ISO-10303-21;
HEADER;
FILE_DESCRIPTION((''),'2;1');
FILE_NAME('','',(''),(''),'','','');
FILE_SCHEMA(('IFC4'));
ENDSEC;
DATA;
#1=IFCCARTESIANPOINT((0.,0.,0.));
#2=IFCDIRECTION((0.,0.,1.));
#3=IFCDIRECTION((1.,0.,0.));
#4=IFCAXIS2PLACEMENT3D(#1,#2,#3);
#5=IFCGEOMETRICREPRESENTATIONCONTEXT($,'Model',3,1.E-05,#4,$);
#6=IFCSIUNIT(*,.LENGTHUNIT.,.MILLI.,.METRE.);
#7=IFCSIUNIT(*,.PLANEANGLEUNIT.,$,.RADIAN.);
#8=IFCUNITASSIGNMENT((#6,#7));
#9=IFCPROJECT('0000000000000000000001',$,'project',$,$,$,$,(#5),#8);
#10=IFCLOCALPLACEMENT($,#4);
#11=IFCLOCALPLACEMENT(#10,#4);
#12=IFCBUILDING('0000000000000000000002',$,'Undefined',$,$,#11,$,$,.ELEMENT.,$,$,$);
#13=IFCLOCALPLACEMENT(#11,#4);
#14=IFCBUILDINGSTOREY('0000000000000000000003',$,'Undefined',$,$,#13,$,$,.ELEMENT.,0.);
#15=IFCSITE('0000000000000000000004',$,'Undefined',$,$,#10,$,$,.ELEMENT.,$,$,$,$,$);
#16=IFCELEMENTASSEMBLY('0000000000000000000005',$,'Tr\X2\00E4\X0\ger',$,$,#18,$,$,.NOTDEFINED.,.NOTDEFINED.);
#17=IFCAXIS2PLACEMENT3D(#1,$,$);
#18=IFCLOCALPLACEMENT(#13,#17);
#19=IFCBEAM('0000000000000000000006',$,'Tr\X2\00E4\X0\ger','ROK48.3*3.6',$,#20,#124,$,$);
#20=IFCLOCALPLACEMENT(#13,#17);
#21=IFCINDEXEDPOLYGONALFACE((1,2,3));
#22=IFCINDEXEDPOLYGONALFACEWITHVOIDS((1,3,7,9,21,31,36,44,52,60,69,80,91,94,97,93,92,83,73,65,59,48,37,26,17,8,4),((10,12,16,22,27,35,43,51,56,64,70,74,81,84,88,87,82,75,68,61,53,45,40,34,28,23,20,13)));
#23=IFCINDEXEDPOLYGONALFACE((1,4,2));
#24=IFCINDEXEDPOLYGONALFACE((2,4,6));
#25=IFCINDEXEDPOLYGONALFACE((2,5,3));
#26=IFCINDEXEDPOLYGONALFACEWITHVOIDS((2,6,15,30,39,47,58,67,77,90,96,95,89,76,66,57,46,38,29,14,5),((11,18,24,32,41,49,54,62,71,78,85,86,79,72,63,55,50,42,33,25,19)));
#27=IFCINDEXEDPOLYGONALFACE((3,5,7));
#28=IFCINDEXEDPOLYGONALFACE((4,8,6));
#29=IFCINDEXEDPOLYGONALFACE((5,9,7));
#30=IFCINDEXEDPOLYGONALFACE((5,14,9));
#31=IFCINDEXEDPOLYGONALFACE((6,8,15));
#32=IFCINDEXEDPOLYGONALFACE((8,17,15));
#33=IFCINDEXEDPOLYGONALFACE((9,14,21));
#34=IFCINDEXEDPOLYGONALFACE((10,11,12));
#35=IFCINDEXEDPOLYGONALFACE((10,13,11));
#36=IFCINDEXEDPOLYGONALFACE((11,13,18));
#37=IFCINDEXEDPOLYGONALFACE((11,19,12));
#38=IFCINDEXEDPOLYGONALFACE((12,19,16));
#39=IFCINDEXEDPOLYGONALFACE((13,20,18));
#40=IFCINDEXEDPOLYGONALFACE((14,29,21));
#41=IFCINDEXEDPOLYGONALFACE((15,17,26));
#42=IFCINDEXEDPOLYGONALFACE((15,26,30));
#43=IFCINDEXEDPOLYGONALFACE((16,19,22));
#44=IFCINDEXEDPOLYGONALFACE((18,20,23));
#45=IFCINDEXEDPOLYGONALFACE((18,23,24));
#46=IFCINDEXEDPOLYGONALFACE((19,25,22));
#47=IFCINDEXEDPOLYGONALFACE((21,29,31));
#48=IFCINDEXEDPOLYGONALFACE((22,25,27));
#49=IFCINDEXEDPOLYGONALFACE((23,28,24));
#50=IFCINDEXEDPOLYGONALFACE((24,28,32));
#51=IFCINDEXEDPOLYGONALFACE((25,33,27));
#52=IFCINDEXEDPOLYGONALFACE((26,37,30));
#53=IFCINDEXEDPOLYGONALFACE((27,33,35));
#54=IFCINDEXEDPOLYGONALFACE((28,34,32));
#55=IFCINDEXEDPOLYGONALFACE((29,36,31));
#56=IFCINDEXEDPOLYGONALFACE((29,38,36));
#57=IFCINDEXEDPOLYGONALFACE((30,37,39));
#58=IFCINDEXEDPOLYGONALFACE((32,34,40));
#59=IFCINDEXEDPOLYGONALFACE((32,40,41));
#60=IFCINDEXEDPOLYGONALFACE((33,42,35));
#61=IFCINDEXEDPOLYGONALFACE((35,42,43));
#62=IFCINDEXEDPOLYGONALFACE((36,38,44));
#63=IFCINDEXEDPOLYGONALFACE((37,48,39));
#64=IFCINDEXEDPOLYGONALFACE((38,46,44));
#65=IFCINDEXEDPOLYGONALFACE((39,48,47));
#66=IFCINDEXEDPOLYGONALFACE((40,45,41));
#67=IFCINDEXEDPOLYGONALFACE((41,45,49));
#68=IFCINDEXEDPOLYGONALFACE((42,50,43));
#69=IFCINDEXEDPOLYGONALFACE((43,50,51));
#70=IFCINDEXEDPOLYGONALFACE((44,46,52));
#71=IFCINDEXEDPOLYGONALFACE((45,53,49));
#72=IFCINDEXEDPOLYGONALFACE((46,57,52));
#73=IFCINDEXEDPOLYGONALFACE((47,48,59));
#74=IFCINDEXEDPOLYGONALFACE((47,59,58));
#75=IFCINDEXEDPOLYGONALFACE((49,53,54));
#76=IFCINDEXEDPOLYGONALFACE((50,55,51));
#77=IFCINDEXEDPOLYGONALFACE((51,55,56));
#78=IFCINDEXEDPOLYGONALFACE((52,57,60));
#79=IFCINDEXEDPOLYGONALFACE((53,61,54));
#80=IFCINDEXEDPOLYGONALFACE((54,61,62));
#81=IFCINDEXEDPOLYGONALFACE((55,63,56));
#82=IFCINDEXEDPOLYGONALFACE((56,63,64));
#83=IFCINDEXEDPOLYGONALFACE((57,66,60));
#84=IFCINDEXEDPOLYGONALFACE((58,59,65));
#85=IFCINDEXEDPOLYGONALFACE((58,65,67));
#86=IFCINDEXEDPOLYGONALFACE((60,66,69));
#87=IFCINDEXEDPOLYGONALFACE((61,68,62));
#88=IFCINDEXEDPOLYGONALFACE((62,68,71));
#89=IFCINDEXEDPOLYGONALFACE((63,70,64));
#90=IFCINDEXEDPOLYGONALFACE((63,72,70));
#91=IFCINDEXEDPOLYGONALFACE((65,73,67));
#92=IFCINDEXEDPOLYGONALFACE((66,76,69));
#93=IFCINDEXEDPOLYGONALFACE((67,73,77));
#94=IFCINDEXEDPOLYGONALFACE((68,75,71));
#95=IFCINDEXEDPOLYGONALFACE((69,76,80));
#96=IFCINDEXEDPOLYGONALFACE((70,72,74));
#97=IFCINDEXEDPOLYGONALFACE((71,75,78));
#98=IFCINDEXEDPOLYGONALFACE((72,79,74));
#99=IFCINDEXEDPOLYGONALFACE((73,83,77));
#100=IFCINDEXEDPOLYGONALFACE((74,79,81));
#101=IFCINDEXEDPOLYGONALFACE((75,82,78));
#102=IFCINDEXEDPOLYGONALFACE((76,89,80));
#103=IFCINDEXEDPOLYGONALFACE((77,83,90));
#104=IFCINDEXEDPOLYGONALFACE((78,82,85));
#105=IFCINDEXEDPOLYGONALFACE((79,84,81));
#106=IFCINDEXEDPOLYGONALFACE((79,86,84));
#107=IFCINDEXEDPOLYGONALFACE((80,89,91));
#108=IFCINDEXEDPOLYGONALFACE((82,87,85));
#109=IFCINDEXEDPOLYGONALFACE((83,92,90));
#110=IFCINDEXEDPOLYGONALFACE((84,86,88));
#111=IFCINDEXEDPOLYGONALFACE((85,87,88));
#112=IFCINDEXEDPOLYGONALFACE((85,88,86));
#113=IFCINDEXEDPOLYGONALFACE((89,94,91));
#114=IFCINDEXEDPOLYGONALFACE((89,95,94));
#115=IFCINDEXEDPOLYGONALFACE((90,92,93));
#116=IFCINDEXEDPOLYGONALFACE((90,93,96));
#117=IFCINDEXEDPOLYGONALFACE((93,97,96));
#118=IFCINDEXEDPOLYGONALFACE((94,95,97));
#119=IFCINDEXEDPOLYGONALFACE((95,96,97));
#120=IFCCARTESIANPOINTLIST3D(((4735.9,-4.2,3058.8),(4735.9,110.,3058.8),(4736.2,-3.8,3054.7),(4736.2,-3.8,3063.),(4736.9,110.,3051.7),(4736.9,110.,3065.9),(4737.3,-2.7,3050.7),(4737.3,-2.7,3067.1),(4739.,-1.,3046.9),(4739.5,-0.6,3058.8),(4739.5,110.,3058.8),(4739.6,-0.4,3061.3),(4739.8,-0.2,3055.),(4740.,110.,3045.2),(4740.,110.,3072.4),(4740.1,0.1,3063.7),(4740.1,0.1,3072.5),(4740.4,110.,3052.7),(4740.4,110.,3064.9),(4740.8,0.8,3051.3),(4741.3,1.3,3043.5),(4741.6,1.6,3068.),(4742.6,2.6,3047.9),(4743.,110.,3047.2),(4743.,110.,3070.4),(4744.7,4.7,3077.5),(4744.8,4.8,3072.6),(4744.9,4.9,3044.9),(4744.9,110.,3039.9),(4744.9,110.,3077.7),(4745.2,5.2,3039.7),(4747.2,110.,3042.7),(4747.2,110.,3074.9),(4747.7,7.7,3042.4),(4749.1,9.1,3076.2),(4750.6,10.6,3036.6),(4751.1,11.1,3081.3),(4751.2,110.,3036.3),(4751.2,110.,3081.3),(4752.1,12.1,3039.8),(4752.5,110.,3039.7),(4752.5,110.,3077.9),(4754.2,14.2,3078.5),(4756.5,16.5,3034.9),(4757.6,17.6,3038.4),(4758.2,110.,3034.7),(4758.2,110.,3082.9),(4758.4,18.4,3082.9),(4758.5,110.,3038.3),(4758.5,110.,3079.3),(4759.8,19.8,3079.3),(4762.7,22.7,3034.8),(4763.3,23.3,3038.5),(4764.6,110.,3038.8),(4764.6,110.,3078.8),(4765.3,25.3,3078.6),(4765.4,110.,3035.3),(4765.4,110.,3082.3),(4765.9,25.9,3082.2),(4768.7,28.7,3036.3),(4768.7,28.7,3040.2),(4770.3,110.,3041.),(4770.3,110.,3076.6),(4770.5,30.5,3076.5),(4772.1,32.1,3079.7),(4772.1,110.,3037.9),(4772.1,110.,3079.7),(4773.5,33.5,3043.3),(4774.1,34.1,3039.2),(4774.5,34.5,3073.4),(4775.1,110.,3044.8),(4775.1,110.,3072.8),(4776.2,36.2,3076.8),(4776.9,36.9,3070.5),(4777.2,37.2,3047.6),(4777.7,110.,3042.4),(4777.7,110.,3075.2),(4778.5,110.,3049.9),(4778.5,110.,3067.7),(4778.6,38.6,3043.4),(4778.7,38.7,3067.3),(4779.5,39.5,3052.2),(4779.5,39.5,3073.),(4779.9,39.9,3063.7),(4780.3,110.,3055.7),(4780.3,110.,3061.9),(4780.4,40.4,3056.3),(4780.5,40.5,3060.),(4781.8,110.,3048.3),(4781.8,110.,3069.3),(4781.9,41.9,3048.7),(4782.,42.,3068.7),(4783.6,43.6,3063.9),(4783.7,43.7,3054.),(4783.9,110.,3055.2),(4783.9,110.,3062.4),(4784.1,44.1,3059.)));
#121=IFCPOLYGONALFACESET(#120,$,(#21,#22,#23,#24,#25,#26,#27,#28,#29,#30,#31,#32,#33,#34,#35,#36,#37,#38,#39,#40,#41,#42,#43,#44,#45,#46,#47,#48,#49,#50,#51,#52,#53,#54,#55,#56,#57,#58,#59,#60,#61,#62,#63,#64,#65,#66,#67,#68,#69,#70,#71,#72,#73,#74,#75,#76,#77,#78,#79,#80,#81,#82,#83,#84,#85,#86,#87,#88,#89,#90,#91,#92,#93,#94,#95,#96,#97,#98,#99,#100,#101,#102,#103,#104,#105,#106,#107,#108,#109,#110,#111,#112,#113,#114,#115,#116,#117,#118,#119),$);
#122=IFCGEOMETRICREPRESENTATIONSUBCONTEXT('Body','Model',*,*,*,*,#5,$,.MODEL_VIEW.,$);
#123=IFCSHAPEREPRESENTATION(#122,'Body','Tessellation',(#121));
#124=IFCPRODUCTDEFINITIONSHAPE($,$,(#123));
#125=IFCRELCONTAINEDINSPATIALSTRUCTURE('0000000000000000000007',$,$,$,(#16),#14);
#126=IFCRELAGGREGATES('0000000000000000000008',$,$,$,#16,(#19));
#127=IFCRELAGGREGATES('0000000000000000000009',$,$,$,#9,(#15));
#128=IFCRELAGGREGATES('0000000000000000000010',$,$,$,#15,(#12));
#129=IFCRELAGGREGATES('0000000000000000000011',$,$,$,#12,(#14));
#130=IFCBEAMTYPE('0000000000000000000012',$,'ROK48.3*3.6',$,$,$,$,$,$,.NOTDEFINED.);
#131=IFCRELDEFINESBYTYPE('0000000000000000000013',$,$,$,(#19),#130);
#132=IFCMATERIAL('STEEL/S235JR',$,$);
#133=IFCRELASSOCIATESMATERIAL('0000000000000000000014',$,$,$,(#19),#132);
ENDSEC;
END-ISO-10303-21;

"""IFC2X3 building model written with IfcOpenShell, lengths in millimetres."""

from ifc_helpers import new_model, si_unit, frame, origin_with_axes, origin_2d_with_axis, place, context, subcontext, project, spatial, hollow_circle, extrude, clip, halfspace, material, type_object, element, aggregate, save


model = new_model("IFC2X3")

# Units and contexts
model_context = context("Model", 3, precision=1e-05, world=origin_with_axes())
body_context = subcontext(model_context, "Body", "Model", "MODEL_VIEW")
ifc_project = project(units=[si_unit("LENGTHUNIT", "METRE", prefix="MILLI"), si_unit("PLANEANGLEUNIT", "RADIAN")], contexts=[model_context])

# Site, building, storey
site_placement = place(None, origin_with_axes())
site = spatial("IfcSite", under=ifc_project, at=site_placement, Name="Undefined", CompositionType="ELEMENT")
building_placement = place(site_placement, origin_with_axes())
building = spatial("IfcBuilding", under=site, at=building_placement, Name="Undefined", CompositionType="ELEMENT")
storey_placement = place(building_placement, origin_with_axes())
storey = spatial("IfcBuildingStorey", under=building, at=storey_placement, Name="Undefined", CompositionType="ELEMENT", Elevation=0.0)

# Element assembly, beam
assembly_1_placement = place(storey_placement, origin_with_axes())
assembly_1 = element("IfcElementAssembly", 1, at=assembly_1_placement, inside=storey, Name="Träger", AssemblyPlace="NOTDEFINED", PredefinedType="NOTDEFINED")
ifc_material = material(Name="STEEL/S235JR")
beam_type = type_object("IfcBeamType", Name="ROK48.3*3.6", PredefinedType="NOTDEFINED")
beam_1_placement = place(assembly_1_placement, frame((4760.0, 56.1, 3058.8), z_axis=(0.0, 0.0, -1.0), x_axis=(0.0, 1.0, 0.0)))
beam_1 = element("IfcBeam", 2, at=beam_1_placement, type_object=beam_type, material=ifc_material, Name="Träger", Description="ROK48.3*3.6", context=body_context, shape_type="Clipping", body=[
    clip(extrude(hollow_circle(Radius=24.1, WallThickness=3.6, at=origin_2d_with_axis()), frame((53.9, 0.0, 0.0), z_axis=(-1.0, 0.0, 0.0), x_axis=(0.0, -1.0, 0.0)), (0.0, 0.0, 1.0), 114.4), halfspace(frame((-60.3, -24.2, 0.0), z_axis=(-0.707107, 0.707107, 0.0), x_axis=(0.0, 0.0, -1.0)), False)),
])

aggregate(assembly_1, [beam_1])

save(model, "model.ifc")
